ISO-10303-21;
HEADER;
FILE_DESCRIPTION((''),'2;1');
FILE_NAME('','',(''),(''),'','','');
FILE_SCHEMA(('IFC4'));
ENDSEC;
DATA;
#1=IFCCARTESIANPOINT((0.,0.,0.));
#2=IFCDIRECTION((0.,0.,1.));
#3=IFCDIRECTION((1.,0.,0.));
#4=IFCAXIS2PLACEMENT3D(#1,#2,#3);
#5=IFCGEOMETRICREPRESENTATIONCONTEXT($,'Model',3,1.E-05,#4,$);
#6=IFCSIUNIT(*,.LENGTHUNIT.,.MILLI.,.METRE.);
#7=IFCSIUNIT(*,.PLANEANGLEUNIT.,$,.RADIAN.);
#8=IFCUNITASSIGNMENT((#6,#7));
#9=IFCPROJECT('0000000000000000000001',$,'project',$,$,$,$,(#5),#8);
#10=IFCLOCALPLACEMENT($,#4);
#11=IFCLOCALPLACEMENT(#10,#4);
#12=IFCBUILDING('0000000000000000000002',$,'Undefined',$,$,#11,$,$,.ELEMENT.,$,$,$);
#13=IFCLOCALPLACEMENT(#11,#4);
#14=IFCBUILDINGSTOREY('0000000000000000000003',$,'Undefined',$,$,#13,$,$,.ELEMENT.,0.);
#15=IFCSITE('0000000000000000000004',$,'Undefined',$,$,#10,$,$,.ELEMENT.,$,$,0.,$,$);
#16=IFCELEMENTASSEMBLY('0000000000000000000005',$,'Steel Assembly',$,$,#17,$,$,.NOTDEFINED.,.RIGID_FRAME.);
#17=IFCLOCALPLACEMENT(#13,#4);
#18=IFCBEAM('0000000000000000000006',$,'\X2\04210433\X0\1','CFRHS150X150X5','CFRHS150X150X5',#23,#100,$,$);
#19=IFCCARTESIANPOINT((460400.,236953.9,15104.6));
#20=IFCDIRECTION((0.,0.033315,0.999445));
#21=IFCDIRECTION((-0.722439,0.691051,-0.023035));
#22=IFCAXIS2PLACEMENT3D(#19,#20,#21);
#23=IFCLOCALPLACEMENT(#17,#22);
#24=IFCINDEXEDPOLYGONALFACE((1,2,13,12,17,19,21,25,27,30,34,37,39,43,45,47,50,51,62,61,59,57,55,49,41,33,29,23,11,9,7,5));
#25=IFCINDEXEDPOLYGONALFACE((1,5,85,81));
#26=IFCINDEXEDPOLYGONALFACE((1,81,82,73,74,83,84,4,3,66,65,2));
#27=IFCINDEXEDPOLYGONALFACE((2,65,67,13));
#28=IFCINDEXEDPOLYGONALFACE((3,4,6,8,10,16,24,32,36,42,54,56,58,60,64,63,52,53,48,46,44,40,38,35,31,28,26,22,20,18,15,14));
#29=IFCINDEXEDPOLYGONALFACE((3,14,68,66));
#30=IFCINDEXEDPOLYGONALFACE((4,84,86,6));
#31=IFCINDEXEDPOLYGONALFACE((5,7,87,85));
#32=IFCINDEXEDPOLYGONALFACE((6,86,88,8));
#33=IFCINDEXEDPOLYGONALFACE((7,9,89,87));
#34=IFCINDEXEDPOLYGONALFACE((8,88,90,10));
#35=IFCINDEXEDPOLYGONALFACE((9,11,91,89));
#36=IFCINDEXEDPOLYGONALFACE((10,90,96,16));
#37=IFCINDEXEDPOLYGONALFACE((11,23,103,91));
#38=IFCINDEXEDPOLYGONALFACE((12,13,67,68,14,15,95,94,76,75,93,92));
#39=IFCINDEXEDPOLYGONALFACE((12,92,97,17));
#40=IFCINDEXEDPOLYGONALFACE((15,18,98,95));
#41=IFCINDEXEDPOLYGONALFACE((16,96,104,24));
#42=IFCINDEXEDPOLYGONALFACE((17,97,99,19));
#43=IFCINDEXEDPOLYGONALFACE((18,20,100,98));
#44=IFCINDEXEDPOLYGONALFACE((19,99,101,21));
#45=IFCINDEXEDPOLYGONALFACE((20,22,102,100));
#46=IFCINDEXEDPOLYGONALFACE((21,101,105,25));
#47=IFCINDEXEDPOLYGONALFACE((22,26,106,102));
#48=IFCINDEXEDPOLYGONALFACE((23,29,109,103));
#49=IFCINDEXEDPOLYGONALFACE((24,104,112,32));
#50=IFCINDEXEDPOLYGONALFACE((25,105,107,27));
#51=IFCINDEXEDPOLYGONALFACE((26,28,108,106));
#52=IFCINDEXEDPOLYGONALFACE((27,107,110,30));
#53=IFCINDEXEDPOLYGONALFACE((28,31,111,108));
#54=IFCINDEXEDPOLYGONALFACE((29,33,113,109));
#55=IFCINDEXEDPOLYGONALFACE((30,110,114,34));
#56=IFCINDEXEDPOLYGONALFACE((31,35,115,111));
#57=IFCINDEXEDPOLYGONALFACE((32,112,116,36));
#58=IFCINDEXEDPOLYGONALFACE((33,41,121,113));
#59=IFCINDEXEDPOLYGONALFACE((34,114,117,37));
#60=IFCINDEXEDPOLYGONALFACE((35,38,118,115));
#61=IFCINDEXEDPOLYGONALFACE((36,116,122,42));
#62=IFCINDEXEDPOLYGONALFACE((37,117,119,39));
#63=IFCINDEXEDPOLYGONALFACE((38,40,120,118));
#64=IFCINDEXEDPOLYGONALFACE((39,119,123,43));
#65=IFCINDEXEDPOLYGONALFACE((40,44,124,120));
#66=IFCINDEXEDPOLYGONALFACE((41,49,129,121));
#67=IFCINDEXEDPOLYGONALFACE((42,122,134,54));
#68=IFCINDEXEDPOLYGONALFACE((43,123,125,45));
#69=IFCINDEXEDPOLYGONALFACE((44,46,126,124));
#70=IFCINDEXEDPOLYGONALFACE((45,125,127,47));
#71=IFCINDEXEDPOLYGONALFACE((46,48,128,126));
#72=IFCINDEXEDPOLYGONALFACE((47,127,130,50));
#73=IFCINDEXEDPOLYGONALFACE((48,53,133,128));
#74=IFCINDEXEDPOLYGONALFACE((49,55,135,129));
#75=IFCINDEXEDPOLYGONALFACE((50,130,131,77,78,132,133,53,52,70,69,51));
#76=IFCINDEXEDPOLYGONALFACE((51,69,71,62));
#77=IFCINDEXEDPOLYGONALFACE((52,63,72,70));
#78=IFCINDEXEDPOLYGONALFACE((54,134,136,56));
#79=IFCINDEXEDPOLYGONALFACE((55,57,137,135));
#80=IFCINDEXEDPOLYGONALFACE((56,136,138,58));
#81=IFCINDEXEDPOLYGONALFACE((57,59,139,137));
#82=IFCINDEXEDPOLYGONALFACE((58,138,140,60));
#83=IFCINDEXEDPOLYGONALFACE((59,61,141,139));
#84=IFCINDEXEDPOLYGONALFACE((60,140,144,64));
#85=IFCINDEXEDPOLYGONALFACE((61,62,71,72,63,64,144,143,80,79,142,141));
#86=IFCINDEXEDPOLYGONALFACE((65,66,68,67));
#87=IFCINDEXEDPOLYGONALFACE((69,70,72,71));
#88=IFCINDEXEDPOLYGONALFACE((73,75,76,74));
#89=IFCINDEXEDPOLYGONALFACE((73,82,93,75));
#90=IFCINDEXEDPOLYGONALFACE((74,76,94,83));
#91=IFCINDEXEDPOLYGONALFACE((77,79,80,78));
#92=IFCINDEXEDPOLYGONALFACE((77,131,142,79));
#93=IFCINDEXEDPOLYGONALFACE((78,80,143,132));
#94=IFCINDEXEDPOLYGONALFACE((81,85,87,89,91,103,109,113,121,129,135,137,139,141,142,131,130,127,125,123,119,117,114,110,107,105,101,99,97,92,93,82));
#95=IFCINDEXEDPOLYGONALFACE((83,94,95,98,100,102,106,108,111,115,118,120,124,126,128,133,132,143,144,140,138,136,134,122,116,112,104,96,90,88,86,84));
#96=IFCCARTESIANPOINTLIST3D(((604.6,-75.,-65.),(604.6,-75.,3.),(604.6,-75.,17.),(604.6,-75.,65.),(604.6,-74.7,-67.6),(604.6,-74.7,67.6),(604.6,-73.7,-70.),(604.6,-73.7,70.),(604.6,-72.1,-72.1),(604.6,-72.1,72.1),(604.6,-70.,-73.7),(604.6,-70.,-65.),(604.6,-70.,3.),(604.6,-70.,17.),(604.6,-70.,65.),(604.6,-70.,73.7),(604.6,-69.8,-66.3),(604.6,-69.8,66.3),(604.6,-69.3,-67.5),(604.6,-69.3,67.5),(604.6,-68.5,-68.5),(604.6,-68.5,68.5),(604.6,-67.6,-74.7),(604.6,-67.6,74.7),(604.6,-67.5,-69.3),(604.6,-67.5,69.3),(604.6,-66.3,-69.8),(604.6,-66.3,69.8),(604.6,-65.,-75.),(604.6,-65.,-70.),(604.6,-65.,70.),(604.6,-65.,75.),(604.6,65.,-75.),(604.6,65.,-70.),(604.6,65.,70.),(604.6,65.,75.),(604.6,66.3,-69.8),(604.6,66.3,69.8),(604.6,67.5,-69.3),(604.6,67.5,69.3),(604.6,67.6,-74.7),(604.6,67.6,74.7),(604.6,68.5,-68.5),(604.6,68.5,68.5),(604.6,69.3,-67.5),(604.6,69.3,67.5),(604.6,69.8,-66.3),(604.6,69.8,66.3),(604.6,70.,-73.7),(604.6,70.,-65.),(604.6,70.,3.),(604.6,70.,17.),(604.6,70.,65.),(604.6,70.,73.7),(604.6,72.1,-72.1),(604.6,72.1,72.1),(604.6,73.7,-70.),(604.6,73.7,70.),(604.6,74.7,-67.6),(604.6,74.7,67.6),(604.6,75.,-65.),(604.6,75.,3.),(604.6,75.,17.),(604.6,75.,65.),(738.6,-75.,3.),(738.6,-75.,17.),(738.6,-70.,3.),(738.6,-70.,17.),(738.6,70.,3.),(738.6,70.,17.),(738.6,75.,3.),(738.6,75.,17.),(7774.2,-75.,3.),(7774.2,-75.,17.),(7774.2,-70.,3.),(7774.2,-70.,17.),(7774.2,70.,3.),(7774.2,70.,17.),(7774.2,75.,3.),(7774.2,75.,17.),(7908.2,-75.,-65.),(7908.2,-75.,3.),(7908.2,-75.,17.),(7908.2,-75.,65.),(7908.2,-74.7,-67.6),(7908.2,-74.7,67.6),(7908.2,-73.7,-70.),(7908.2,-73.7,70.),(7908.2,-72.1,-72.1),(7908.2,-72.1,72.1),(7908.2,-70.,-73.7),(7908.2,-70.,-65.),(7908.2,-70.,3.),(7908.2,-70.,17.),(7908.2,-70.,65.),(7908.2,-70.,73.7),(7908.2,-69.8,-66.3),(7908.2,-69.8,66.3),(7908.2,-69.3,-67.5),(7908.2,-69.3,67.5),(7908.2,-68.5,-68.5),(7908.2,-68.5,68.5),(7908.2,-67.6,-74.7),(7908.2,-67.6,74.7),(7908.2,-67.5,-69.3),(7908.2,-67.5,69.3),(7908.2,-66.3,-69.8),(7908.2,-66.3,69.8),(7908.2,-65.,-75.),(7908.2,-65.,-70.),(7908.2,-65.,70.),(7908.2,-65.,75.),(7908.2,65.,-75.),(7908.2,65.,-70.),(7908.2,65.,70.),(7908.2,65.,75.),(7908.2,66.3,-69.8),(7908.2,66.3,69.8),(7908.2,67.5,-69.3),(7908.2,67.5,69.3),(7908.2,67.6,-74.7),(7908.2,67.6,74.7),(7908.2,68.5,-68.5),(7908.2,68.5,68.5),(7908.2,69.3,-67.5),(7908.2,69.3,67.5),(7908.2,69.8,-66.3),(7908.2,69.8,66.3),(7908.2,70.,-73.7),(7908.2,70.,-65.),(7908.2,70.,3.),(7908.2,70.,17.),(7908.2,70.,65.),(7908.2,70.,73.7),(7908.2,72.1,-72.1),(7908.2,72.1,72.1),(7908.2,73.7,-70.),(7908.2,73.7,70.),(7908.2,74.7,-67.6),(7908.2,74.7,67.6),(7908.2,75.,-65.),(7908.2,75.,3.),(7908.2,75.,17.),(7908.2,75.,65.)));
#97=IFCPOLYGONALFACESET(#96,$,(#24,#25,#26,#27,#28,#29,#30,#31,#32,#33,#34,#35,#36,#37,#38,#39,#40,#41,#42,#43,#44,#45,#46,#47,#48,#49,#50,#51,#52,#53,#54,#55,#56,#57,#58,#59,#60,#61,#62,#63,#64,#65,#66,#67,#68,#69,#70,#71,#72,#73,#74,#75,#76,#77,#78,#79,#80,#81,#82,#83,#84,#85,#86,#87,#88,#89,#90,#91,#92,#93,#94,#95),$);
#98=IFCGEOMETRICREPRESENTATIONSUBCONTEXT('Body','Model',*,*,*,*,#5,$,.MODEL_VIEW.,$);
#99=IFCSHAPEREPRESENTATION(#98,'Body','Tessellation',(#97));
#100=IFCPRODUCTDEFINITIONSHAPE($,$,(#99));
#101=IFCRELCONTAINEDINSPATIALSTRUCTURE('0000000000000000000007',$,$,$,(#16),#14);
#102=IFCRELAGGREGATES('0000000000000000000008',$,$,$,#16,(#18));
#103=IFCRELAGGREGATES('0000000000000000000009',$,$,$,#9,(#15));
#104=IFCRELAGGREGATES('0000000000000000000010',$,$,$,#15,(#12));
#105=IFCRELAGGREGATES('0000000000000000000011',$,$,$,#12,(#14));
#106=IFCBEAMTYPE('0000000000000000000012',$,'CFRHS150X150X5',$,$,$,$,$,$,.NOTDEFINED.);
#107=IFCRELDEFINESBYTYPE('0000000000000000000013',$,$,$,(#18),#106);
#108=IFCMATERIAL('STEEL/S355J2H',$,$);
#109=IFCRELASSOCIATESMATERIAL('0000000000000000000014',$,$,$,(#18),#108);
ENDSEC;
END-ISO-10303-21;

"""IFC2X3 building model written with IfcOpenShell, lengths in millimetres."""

from ifc_helpers import new_model, si_unit, frame, origin_with_axes, origin_2d_with_axis, place, context, subcontext, project, spatial, polyline, hollow_rectangle, outline, extrude, boolean, material, type_object, element, aggregate, save


model = new_model("IFC2X3")

# Units and contexts
model_context = context("Model", 3, precision=1e-05, world=origin_with_axes())
body_context = subcontext(model_context, "Body", "Model", "MODEL_VIEW")
ifc_project = project(units=[si_unit("LENGTHUNIT", "METRE", prefix="MILLI"), si_unit("PLANEANGLEUNIT", "RADIAN")], contexts=[model_context])

# Site, building, storey
site_placement = place(None, origin_with_axes())
site = spatial("IfcSite", under=ifc_project, at=site_placement, Name="Undefined", CompositionType="ELEMENT", RefElevation=0.0)
building_placement = place(site_placement, origin_with_axes())
building = spatial("IfcBuilding", under=site, at=building_placement, Name="Undefined", CompositionType="ELEMENT")
storey_placement = place(building_placement, origin_with_axes())
storey = spatial("IfcBuildingStorey", under=building, at=storey_placement, Name="Undefined", CompositionType="ELEMENT", Elevation=0.0)

# Element assembly, beam
assembly_1_placement = place(storey_placement, origin_with_axes())
assembly_1 = element("IfcElementAssembly", 1, at=assembly_1_placement, inside=storey, Name="Steel Assembly", AssemblyPlace="NOTDEFINED", PredefinedType="RIGID_FRAME")
ifc_material_1 = material(Name="STEEL/S355J2H")
beam_type_1 = type_object("IfcBeamType", Name="CFRHS150X150X5", PredefinedType="NOTDEFINED")
beam_1_placement = place(assembly_1_placement, frame((460400.0, 236953.9, 15104.6), z_axis=(0.0, 0.033315, 0.999445), x_axis=(-0.722439, 0.691051, -0.023035)))
beam_1 = element("IfcBeam", 2, at=beam_1_placement, type_object=beam_type_1, material=ifc_material_1, Name="Сг1", Description="CFRHS150X150X5", ObjectType="CFRHS150X150X5", context=body_context, shape_type="CSG", body=[
    boolean("DIFFERENCE", boolean("DIFFERENCE", extrude(hollow_rectangle(XDim=150.0, YDim=150.0, WallThickness=5.0, InnerFilletRadius=5.0, OuterFilletRadius=10.0, at=origin_2d_with_axis()), frame((7908.2, 0.0, 0.0), z_axis=(-1.0, 0.0, 0.0), x_axis=(0.0, -1.0, 0.0)), (0.0, 0.0, 1.0), 7303.6), extrude(outline(polyline([(0.0, 0.0), (159.4, 0.0), (159.4, 14.0), (0.0, 14.0), (0.0, 0.0)])), frame((7933.6, -100.4, 3.0), z_axis=(0.0, 1.0, 0.000093), x_axis=(-1.0, 0.0, 0.0)), (0.0, 0.0, 1.0), 200.8)), extrude(outline(polyline([(0.0, 0.0), (159.4, 0.0), (159.4, 14.0), (0.0, 14.0), (0.0, 0.0)])), frame((579.2, 100.4, 3.0), z_axis=(0.0, -1.0, -0.000098), x_axis=(1.0, 0.0, 0.0)), (0.0, 0.0, 1.0), 200.8)),
])

aggregate(assembly_1, [beam_1])

save(model, "model.ifc")
